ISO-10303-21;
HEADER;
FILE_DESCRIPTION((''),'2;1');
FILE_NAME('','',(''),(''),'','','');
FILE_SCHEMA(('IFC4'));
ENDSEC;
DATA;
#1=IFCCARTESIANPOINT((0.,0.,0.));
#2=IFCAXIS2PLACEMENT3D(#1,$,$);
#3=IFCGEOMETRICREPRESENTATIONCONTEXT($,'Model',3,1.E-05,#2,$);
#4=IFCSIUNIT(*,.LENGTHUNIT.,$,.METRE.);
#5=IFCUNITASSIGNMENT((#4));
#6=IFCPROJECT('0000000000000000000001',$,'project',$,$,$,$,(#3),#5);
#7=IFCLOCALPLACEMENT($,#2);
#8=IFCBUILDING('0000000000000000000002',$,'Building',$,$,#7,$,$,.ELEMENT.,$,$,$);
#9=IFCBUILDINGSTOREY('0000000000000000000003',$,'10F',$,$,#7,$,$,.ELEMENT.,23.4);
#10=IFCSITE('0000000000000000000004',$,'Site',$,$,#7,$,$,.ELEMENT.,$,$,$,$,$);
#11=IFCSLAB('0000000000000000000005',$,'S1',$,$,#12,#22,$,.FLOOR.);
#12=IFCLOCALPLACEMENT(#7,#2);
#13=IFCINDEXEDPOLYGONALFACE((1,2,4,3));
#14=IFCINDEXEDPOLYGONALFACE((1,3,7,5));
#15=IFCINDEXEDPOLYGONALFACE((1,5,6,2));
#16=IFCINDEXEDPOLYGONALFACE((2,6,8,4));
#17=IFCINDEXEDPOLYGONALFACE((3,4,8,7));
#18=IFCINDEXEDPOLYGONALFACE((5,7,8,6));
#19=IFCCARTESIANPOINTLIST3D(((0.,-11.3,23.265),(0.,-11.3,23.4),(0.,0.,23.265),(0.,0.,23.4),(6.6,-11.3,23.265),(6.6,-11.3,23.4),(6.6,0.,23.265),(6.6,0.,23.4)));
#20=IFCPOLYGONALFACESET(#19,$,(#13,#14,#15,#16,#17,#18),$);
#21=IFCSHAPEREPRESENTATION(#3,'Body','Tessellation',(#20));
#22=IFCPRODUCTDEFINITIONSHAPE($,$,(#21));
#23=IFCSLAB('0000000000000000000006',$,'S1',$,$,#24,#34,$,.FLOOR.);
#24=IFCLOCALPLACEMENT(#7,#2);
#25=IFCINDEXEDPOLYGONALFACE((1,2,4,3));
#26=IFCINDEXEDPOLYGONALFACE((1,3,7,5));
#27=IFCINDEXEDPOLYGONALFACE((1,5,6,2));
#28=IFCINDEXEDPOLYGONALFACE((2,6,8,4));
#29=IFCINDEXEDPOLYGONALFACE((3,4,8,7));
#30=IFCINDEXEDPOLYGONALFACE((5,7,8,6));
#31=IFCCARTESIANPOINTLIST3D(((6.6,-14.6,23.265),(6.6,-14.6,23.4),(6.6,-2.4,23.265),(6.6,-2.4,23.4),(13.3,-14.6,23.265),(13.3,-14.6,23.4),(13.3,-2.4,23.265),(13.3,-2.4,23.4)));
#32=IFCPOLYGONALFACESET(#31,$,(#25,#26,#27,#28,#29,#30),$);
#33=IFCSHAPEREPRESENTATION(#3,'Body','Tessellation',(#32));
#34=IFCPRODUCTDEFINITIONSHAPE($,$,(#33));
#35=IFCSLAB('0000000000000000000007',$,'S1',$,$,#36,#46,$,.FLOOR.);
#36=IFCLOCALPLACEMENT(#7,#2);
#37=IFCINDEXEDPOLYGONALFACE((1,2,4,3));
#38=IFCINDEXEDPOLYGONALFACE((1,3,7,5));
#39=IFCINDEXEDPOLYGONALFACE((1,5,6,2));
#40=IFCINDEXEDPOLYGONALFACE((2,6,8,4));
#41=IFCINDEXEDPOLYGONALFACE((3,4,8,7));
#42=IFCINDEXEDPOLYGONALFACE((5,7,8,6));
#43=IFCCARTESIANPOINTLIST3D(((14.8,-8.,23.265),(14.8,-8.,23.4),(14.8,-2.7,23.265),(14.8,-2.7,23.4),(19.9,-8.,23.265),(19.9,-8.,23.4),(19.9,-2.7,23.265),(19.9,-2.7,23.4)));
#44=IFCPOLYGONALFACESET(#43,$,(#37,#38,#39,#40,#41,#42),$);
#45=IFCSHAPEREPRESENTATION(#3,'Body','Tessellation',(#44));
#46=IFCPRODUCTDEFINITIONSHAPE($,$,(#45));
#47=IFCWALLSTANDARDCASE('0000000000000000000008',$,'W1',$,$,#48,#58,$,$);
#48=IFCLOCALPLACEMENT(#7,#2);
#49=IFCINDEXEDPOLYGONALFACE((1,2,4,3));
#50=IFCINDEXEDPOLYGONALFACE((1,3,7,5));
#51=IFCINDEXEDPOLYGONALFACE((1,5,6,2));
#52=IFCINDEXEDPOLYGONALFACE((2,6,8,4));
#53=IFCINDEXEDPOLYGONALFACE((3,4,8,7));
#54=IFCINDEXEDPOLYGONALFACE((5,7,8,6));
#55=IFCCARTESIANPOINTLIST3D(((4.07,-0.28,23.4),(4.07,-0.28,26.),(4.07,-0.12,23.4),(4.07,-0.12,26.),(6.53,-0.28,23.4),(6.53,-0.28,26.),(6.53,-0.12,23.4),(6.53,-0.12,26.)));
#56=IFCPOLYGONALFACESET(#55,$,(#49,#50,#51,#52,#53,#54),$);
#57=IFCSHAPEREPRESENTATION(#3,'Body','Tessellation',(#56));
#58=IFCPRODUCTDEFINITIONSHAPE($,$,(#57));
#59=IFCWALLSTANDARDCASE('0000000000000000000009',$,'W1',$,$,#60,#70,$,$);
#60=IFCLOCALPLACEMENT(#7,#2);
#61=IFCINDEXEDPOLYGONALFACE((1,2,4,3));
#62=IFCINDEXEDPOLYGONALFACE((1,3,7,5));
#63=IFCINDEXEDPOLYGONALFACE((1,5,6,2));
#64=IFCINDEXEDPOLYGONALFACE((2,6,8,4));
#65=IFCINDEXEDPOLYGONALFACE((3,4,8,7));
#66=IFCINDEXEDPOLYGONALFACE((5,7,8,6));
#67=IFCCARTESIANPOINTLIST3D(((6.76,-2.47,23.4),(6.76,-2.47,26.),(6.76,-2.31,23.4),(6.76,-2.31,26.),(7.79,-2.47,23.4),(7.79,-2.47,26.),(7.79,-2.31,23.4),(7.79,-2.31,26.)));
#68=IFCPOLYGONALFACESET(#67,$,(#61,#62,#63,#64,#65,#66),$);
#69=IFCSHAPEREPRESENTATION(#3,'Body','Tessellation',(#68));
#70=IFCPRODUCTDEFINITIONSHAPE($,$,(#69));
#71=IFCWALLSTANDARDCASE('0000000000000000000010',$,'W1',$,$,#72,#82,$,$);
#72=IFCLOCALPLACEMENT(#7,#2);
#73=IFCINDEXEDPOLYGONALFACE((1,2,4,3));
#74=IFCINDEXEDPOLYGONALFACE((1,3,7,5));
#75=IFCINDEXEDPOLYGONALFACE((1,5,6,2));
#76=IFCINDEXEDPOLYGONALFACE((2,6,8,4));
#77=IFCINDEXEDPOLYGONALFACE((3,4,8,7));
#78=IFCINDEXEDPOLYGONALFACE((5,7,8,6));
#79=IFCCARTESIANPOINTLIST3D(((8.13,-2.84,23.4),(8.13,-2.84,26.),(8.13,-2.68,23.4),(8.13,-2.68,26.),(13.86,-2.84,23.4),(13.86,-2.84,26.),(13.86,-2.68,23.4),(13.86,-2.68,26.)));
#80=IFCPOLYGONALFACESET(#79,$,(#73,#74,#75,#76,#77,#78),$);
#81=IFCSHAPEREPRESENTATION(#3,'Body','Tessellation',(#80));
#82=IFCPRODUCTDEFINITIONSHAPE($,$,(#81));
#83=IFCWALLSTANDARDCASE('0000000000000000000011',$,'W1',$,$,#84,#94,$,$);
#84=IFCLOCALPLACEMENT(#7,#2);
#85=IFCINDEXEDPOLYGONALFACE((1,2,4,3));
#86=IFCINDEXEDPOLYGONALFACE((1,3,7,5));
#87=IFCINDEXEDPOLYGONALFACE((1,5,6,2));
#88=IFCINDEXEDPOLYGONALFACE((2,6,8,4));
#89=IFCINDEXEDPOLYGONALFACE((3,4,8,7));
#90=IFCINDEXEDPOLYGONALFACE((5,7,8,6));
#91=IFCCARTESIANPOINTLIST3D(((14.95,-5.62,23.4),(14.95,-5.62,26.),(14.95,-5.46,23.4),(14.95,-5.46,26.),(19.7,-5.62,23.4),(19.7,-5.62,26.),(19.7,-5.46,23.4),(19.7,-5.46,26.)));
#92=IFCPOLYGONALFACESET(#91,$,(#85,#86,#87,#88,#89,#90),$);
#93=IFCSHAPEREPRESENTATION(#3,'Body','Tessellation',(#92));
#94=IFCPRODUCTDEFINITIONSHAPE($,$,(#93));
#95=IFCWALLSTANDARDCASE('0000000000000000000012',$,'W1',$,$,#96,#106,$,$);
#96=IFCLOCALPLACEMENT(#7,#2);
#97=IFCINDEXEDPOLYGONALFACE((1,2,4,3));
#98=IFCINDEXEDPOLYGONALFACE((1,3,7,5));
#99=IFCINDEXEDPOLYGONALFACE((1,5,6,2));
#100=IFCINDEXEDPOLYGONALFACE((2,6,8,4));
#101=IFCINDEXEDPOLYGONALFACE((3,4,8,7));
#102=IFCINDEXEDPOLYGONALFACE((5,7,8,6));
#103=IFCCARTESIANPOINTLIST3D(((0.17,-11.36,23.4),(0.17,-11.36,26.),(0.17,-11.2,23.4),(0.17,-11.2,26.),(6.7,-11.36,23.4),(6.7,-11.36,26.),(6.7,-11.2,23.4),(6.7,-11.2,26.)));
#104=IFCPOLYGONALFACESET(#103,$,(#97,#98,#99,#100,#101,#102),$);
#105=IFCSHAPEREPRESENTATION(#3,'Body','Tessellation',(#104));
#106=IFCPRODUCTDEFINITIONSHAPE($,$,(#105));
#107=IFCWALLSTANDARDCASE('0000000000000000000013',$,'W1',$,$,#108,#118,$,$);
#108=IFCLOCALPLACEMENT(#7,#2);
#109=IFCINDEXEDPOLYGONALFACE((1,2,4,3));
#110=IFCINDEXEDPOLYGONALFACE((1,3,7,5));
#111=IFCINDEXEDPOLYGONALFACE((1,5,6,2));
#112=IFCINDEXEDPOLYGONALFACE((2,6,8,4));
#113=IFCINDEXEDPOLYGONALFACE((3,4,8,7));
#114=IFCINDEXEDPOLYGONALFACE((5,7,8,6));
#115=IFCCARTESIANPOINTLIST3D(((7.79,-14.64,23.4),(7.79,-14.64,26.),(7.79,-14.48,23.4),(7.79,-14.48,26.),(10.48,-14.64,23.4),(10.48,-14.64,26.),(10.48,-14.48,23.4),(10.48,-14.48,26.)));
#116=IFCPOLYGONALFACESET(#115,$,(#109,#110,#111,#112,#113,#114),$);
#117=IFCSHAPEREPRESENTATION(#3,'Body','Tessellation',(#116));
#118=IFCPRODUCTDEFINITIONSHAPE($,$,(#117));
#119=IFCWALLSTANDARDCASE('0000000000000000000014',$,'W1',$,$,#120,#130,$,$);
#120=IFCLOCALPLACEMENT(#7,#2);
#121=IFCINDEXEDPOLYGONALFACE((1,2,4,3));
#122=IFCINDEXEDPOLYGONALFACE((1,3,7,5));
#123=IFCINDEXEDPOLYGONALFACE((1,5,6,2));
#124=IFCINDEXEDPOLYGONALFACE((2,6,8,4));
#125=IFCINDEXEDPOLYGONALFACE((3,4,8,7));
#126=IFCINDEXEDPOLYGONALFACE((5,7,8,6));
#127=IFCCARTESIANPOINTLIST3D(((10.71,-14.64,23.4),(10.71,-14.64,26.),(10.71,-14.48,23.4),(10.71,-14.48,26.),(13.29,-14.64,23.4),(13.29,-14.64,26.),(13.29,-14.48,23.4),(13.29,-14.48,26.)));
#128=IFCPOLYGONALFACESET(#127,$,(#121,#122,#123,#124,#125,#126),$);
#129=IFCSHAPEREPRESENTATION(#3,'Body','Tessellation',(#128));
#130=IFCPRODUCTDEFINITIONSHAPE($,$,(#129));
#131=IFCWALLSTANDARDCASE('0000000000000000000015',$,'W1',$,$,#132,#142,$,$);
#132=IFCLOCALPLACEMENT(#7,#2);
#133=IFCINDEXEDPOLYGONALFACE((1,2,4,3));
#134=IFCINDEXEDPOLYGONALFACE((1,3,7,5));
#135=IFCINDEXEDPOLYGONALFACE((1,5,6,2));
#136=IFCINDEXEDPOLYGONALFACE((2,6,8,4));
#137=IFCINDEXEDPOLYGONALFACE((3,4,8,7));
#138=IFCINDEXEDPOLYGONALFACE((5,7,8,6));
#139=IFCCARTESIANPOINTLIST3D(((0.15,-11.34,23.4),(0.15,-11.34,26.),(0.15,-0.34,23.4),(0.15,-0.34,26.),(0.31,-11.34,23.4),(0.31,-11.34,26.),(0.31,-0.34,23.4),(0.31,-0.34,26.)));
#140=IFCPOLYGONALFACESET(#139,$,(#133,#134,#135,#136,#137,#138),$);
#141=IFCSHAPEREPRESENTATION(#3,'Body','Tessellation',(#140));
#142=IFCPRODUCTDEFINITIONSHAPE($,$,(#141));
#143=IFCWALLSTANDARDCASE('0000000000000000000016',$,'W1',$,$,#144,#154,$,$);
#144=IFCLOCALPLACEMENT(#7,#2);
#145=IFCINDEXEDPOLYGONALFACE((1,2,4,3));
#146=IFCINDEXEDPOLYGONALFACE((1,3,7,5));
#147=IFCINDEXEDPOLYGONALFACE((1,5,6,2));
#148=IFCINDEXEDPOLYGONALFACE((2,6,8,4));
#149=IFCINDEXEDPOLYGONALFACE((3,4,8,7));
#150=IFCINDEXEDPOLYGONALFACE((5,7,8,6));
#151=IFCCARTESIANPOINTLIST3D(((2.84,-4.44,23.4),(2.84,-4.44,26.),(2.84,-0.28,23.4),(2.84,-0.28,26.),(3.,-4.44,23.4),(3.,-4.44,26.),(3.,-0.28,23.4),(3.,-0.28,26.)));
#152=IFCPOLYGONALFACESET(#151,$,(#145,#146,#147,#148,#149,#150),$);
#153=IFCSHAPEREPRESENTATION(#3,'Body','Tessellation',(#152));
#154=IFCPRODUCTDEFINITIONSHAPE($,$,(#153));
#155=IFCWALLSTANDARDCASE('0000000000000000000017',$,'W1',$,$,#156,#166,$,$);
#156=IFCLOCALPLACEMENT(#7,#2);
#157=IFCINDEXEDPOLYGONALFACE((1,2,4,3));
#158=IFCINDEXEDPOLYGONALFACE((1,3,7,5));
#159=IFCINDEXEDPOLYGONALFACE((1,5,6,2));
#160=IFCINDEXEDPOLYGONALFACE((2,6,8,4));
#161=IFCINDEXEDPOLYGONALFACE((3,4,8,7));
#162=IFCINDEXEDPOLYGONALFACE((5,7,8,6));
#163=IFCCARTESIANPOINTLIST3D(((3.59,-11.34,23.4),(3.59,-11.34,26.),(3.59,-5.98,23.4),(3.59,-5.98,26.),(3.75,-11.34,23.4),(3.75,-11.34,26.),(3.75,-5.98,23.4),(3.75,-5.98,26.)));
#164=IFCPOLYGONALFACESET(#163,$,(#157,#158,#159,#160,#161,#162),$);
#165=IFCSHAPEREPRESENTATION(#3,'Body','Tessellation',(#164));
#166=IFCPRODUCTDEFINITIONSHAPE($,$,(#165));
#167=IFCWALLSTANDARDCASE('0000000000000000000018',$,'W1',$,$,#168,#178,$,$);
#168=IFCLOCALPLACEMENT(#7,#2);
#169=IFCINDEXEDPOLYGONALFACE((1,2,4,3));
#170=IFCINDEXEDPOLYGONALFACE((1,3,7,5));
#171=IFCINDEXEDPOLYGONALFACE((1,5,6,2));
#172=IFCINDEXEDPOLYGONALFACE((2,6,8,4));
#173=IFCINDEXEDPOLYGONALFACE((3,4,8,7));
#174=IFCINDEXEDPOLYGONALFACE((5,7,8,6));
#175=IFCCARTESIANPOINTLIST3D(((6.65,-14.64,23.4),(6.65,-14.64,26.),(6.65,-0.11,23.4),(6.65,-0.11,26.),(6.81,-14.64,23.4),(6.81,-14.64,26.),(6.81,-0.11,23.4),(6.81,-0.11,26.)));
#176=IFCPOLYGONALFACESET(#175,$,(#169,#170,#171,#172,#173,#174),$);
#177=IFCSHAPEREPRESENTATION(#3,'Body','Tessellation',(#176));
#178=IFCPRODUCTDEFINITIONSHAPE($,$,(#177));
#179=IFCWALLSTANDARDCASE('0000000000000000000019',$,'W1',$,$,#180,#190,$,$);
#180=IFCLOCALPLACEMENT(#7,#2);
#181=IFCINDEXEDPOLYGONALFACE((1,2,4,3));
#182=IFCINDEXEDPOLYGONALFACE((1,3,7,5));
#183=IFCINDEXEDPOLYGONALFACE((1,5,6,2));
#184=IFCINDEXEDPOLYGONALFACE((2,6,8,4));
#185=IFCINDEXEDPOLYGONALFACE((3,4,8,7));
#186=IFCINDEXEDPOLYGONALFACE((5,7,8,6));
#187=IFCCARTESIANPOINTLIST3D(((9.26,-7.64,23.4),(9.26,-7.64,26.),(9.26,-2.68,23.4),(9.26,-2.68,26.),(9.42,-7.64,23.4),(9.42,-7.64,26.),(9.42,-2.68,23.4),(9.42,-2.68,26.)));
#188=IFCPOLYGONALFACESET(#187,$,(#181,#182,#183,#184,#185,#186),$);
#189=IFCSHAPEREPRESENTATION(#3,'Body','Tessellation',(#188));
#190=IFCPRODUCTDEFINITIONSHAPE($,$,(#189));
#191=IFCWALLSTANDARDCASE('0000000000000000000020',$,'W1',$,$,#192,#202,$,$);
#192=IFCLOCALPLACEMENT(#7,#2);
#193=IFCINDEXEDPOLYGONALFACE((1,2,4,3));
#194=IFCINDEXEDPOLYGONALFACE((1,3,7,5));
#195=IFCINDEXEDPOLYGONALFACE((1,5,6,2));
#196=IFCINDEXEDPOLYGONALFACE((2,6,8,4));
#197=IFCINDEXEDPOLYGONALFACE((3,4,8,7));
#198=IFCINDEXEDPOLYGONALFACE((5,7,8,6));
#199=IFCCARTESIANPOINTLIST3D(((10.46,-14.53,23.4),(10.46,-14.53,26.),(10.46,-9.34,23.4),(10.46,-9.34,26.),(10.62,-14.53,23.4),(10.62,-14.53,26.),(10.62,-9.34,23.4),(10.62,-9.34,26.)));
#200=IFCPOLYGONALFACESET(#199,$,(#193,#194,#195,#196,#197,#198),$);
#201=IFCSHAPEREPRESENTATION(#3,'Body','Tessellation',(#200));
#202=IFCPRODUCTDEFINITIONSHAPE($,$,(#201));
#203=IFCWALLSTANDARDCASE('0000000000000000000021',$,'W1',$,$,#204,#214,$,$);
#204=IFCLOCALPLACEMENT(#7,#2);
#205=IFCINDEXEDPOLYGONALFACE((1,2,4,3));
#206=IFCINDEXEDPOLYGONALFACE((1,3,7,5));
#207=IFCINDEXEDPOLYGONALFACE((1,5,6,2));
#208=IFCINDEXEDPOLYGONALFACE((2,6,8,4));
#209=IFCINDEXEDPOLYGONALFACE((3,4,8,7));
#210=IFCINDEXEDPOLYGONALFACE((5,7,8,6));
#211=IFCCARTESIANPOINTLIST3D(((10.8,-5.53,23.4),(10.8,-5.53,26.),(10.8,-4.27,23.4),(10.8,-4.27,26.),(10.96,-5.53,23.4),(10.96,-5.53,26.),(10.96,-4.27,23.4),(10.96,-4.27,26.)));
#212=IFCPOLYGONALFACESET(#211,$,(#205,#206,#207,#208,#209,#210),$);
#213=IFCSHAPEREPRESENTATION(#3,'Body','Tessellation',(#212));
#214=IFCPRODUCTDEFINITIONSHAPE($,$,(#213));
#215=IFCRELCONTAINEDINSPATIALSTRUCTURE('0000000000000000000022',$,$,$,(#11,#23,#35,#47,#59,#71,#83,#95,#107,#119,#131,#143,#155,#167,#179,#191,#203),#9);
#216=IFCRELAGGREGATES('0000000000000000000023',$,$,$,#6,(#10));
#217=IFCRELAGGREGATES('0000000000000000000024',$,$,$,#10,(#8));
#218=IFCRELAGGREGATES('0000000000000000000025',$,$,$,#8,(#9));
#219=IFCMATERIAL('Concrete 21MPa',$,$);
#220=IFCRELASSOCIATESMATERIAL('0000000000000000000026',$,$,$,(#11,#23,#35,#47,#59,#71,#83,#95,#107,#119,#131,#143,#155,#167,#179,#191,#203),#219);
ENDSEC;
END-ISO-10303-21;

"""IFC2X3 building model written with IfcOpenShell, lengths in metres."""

from ifc_helpers import new_model, si_unit, frame, origin, origin_2d, place, context, project, spatial, rectangle, extrude, material, element, save


model = new_model("IFC2X3")

# Units and contexts
model_context = context("Model", 3, precision=1e-05, world=origin())
ifc_project = project(units=[si_unit("LENGTHUNIT", "METRE")], contexts=[model_context])

# Site, building, storey
placement = place(None, origin())
site = spatial("IfcSite", under=ifc_project, at=placement, Name="Site", CompositionType="ELEMENT")
building = spatial("IfcBuilding", under=site, at=placement, Name="Building", CompositionType="ELEMENT")
storey = spatial("IfcBuildingStorey", under=building, at=placement, Name="10F", CompositionType="ELEMENT", Elevation=23.4)

# Slabs
ifc_material_1 = material(Name="Concrete 21MPa")
slab_1_placement = place(None, frame((3.3, -5.65, 23.265)))
element("IfcSlab", 1, at=slab_1_placement, inside=storey, material=ifc_material_1, Name="S1", PredefinedType="FLOOR", context=model_context, shape_type="SweptSolid", body=[
    extrude(rectangle(XDim=6.6, YDim=11.3, at=origin_2d()), origin(), (0.0, 0.0, 1.0), 0.135),
])
slab_2_placement = place(None, frame((9.95, -8.5, 23.265)))
element("IfcSlab", 2, at=slab_2_placement, inside=storey, material=ifc_material_1, Name="S1", PredefinedType="FLOOR", context=model_context, shape_type="SweptSolid", body=[
    extrude(rectangle(XDim=6.7, YDim=12.2, at=origin_2d()), origin(), (0.0, 0.0, 1.0), 0.135),
])
slab_3_placement = place(None, frame((17.35, -5.35, 23.265)))
element("IfcSlab", 3, at=slab_3_placement, inside=storey, material=ifc_material_1, Name="S1", PredefinedType="FLOOR", context=model_context, shape_type="SweptSolid", body=[
    extrude(rectangle(XDim=5.1, YDim=5.3, at=origin_2d()), origin(), (0.0, 0.0, 1.0), 0.135),
])

# Walls
wall_1_placement = place(None, frame((5.3, -0.2, 23.4)))
element("IfcWallStandardCase", 4, at=wall_1_placement, inside=storey, material=ifc_material_1, Name="W1", context=model_context, shape_type="SweptSolid", body=[
    extrude(rectangle(XDim=2.46, YDim=0.16, at=origin_2d()), origin(), (0.0, 0.0, 1.0), 2.6),
])
wall_2_placement = place(None, frame((7.275, -2.39, 23.4)))
element("IfcWallStandardCase", 5, at=wall_2_placement, inside=storey, material=ifc_material_1, Name="W1", context=model_context, shape_type="SweptSolid", body=[
    extrude(rectangle(XDim=1.03, YDim=0.16, at=origin_2d()), origin(), (0.0, 0.0, 1.0), 2.6),
])
wall_3_placement = place(None, frame((10.995, -2.76, 23.4)))
element("IfcWallStandardCase", 6, at=wall_3_placement, inside=storey, material=ifc_material_1, Name="W1", context=model_context, shape_type="SweptSolid", body=[
    extrude(rectangle(XDim=5.73, YDim=0.16, at=origin_2d()), origin(), (0.0, 0.0, 1.0), 2.6),
])
wall_4_placement = place(None, frame((17.325, -5.54, 23.4)))
element("IfcWallStandardCase", 7, at=wall_4_placement, inside=storey, material=ifc_material_1, Name="W1", context=model_context, shape_type="SweptSolid", body=[
    extrude(rectangle(XDim=4.75, YDim=0.16, at=origin_2d()), origin(), (0.0, 0.0, 1.0), 2.6),
])
wall_5_placement = place(None, frame((3.435, -11.28, 23.4)))
element("IfcWallStandardCase", 8, at=wall_5_placement, inside=storey, material=ifc_material_1, Name="W1", context=model_context, shape_type="SweptSolid", body=[
    extrude(rectangle(XDim=6.53, YDim=0.16, at=origin_2d()), origin(), (0.0, 0.0, 1.0), 2.6),
])
wall_6_placement = place(None, frame((9.135, -14.56, 23.4)))
element("IfcWallStandardCase", 9, at=wall_6_placement, inside=storey, material=ifc_material_1, Name="W1", context=model_context, shape_type="SweptSolid", body=[
    extrude(rectangle(XDim=2.69, YDim=0.16, at=origin_2d()), origin(), (0.0, 0.0, 1.0), 2.6),
])
wall_7_placement = place(None, frame((12.0, -14.56, 23.4)))
element("IfcWallStandardCase", 10, at=wall_7_placement, inside=storey, material=ifc_material_1, Name="W1", context=model_context, shape_type="SweptSolid", body=[
    extrude(rectangle(XDim=2.58, YDim=0.16, at=origin_2d()), origin(), (0.0, 0.0, 1.0), 2.6),
])
wall_8_placement = place(None, frame((0.23, -5.84, 23.4)))
element("IfcWallStandardCase", 11, at=wall_8_placement, inside=storey, material=ifc_material_1, Name="W1", context=model_context, shape_type="SweptSolid", body=[
    extrude(rectangle(XDim=0.16, YDim=11.0, at=origin_2d()), origin(), (0.0, 0.0, 1.0), 2.6),
])
wall_9_placement = place(None, frame((2.92, -2.36, 23.4)))
element("IfcWallStandardCase", 12, at=wall_9_placement, inside=storey, material=ifc_material_1, Name="W1", context=model_context, shape_type="SweptSolid", body=[
    extrude(rectangle(XDim=0.16, YDim=4.16, at=origin_2d()), origin(), (0.0, 0.0, 1.0), 2.6),
])
wall_10_placement = place(None, frame((3.67, -8.66, 23.4)))
element("IfcWallStandardCase", 13, at=wall_10_placement, inside=storey, material=ifc_material_1, Name="W1", context=model_context, shape_type="SweptSolid", body=[
    extrude(rectangle(XDim=0.16, YDim=5.36, at=origin_2d()), origin(), (0.0, 0.0, 1.0), 2.6),
])
wall_11_placement = place(None, frame((6.73, -7.375, 23.4)))
element("IfcWallStandardCase", 14, at=wall_11_placement, inside=storey, material=ifc_material_1, Name="W1", context=model_context, shape_type="SweptSolid", body=[
    extrude(rectangle(XDim=0.16, YDim=14.53, at=origin_2d()), origin(), (0.0, 0.0, 1.0), 2.6),
])
wall_12_placement = place(None, frame((9.34, -5.16, 23.4)))
element("IfcWallStandardCase", 15, at=wall_12_placement, inside=storey, material=ifc_material_1, Name="W1", context=model_context, shape_type="SweptSolid", body=[
    extrude(rectangle(XDim=0.16, YDim=4.96, at=origin_2d()), origin(), (0.0, 0.0, 1.0), 2.6),
])
wall_13_placement = place(None, frame((10.54, -11.935, 23.4)))
element("IfcWallStandardCase", 16, at=wall_13_placement, inside=storey, material=ifc_material_1, Name="W1", context=model_context, shape_type="SweptSolid", body=[
    extrude(rectangle(XDim=0.16, YDim=5.19, at=origin_2d()), origin(), (0.0, 0.0, 1.0), 2.6),
])
wall_14_placement = place(None, frame((10.88, -4.9, 23.4)))
element("IfcWallStandardCase", 17, at=wall_14_placement, inside=storey, material=ifc_material_1, Name="W1", context=model_context, shape_type="SweptSolid", body=[
    extrude(rectangle(XDim=0.16, YDim=1.26, at=origin_2d()), origin(), (0.0, 0.0, 1.0), 2.6),
])

save(model, "model.ifc")
